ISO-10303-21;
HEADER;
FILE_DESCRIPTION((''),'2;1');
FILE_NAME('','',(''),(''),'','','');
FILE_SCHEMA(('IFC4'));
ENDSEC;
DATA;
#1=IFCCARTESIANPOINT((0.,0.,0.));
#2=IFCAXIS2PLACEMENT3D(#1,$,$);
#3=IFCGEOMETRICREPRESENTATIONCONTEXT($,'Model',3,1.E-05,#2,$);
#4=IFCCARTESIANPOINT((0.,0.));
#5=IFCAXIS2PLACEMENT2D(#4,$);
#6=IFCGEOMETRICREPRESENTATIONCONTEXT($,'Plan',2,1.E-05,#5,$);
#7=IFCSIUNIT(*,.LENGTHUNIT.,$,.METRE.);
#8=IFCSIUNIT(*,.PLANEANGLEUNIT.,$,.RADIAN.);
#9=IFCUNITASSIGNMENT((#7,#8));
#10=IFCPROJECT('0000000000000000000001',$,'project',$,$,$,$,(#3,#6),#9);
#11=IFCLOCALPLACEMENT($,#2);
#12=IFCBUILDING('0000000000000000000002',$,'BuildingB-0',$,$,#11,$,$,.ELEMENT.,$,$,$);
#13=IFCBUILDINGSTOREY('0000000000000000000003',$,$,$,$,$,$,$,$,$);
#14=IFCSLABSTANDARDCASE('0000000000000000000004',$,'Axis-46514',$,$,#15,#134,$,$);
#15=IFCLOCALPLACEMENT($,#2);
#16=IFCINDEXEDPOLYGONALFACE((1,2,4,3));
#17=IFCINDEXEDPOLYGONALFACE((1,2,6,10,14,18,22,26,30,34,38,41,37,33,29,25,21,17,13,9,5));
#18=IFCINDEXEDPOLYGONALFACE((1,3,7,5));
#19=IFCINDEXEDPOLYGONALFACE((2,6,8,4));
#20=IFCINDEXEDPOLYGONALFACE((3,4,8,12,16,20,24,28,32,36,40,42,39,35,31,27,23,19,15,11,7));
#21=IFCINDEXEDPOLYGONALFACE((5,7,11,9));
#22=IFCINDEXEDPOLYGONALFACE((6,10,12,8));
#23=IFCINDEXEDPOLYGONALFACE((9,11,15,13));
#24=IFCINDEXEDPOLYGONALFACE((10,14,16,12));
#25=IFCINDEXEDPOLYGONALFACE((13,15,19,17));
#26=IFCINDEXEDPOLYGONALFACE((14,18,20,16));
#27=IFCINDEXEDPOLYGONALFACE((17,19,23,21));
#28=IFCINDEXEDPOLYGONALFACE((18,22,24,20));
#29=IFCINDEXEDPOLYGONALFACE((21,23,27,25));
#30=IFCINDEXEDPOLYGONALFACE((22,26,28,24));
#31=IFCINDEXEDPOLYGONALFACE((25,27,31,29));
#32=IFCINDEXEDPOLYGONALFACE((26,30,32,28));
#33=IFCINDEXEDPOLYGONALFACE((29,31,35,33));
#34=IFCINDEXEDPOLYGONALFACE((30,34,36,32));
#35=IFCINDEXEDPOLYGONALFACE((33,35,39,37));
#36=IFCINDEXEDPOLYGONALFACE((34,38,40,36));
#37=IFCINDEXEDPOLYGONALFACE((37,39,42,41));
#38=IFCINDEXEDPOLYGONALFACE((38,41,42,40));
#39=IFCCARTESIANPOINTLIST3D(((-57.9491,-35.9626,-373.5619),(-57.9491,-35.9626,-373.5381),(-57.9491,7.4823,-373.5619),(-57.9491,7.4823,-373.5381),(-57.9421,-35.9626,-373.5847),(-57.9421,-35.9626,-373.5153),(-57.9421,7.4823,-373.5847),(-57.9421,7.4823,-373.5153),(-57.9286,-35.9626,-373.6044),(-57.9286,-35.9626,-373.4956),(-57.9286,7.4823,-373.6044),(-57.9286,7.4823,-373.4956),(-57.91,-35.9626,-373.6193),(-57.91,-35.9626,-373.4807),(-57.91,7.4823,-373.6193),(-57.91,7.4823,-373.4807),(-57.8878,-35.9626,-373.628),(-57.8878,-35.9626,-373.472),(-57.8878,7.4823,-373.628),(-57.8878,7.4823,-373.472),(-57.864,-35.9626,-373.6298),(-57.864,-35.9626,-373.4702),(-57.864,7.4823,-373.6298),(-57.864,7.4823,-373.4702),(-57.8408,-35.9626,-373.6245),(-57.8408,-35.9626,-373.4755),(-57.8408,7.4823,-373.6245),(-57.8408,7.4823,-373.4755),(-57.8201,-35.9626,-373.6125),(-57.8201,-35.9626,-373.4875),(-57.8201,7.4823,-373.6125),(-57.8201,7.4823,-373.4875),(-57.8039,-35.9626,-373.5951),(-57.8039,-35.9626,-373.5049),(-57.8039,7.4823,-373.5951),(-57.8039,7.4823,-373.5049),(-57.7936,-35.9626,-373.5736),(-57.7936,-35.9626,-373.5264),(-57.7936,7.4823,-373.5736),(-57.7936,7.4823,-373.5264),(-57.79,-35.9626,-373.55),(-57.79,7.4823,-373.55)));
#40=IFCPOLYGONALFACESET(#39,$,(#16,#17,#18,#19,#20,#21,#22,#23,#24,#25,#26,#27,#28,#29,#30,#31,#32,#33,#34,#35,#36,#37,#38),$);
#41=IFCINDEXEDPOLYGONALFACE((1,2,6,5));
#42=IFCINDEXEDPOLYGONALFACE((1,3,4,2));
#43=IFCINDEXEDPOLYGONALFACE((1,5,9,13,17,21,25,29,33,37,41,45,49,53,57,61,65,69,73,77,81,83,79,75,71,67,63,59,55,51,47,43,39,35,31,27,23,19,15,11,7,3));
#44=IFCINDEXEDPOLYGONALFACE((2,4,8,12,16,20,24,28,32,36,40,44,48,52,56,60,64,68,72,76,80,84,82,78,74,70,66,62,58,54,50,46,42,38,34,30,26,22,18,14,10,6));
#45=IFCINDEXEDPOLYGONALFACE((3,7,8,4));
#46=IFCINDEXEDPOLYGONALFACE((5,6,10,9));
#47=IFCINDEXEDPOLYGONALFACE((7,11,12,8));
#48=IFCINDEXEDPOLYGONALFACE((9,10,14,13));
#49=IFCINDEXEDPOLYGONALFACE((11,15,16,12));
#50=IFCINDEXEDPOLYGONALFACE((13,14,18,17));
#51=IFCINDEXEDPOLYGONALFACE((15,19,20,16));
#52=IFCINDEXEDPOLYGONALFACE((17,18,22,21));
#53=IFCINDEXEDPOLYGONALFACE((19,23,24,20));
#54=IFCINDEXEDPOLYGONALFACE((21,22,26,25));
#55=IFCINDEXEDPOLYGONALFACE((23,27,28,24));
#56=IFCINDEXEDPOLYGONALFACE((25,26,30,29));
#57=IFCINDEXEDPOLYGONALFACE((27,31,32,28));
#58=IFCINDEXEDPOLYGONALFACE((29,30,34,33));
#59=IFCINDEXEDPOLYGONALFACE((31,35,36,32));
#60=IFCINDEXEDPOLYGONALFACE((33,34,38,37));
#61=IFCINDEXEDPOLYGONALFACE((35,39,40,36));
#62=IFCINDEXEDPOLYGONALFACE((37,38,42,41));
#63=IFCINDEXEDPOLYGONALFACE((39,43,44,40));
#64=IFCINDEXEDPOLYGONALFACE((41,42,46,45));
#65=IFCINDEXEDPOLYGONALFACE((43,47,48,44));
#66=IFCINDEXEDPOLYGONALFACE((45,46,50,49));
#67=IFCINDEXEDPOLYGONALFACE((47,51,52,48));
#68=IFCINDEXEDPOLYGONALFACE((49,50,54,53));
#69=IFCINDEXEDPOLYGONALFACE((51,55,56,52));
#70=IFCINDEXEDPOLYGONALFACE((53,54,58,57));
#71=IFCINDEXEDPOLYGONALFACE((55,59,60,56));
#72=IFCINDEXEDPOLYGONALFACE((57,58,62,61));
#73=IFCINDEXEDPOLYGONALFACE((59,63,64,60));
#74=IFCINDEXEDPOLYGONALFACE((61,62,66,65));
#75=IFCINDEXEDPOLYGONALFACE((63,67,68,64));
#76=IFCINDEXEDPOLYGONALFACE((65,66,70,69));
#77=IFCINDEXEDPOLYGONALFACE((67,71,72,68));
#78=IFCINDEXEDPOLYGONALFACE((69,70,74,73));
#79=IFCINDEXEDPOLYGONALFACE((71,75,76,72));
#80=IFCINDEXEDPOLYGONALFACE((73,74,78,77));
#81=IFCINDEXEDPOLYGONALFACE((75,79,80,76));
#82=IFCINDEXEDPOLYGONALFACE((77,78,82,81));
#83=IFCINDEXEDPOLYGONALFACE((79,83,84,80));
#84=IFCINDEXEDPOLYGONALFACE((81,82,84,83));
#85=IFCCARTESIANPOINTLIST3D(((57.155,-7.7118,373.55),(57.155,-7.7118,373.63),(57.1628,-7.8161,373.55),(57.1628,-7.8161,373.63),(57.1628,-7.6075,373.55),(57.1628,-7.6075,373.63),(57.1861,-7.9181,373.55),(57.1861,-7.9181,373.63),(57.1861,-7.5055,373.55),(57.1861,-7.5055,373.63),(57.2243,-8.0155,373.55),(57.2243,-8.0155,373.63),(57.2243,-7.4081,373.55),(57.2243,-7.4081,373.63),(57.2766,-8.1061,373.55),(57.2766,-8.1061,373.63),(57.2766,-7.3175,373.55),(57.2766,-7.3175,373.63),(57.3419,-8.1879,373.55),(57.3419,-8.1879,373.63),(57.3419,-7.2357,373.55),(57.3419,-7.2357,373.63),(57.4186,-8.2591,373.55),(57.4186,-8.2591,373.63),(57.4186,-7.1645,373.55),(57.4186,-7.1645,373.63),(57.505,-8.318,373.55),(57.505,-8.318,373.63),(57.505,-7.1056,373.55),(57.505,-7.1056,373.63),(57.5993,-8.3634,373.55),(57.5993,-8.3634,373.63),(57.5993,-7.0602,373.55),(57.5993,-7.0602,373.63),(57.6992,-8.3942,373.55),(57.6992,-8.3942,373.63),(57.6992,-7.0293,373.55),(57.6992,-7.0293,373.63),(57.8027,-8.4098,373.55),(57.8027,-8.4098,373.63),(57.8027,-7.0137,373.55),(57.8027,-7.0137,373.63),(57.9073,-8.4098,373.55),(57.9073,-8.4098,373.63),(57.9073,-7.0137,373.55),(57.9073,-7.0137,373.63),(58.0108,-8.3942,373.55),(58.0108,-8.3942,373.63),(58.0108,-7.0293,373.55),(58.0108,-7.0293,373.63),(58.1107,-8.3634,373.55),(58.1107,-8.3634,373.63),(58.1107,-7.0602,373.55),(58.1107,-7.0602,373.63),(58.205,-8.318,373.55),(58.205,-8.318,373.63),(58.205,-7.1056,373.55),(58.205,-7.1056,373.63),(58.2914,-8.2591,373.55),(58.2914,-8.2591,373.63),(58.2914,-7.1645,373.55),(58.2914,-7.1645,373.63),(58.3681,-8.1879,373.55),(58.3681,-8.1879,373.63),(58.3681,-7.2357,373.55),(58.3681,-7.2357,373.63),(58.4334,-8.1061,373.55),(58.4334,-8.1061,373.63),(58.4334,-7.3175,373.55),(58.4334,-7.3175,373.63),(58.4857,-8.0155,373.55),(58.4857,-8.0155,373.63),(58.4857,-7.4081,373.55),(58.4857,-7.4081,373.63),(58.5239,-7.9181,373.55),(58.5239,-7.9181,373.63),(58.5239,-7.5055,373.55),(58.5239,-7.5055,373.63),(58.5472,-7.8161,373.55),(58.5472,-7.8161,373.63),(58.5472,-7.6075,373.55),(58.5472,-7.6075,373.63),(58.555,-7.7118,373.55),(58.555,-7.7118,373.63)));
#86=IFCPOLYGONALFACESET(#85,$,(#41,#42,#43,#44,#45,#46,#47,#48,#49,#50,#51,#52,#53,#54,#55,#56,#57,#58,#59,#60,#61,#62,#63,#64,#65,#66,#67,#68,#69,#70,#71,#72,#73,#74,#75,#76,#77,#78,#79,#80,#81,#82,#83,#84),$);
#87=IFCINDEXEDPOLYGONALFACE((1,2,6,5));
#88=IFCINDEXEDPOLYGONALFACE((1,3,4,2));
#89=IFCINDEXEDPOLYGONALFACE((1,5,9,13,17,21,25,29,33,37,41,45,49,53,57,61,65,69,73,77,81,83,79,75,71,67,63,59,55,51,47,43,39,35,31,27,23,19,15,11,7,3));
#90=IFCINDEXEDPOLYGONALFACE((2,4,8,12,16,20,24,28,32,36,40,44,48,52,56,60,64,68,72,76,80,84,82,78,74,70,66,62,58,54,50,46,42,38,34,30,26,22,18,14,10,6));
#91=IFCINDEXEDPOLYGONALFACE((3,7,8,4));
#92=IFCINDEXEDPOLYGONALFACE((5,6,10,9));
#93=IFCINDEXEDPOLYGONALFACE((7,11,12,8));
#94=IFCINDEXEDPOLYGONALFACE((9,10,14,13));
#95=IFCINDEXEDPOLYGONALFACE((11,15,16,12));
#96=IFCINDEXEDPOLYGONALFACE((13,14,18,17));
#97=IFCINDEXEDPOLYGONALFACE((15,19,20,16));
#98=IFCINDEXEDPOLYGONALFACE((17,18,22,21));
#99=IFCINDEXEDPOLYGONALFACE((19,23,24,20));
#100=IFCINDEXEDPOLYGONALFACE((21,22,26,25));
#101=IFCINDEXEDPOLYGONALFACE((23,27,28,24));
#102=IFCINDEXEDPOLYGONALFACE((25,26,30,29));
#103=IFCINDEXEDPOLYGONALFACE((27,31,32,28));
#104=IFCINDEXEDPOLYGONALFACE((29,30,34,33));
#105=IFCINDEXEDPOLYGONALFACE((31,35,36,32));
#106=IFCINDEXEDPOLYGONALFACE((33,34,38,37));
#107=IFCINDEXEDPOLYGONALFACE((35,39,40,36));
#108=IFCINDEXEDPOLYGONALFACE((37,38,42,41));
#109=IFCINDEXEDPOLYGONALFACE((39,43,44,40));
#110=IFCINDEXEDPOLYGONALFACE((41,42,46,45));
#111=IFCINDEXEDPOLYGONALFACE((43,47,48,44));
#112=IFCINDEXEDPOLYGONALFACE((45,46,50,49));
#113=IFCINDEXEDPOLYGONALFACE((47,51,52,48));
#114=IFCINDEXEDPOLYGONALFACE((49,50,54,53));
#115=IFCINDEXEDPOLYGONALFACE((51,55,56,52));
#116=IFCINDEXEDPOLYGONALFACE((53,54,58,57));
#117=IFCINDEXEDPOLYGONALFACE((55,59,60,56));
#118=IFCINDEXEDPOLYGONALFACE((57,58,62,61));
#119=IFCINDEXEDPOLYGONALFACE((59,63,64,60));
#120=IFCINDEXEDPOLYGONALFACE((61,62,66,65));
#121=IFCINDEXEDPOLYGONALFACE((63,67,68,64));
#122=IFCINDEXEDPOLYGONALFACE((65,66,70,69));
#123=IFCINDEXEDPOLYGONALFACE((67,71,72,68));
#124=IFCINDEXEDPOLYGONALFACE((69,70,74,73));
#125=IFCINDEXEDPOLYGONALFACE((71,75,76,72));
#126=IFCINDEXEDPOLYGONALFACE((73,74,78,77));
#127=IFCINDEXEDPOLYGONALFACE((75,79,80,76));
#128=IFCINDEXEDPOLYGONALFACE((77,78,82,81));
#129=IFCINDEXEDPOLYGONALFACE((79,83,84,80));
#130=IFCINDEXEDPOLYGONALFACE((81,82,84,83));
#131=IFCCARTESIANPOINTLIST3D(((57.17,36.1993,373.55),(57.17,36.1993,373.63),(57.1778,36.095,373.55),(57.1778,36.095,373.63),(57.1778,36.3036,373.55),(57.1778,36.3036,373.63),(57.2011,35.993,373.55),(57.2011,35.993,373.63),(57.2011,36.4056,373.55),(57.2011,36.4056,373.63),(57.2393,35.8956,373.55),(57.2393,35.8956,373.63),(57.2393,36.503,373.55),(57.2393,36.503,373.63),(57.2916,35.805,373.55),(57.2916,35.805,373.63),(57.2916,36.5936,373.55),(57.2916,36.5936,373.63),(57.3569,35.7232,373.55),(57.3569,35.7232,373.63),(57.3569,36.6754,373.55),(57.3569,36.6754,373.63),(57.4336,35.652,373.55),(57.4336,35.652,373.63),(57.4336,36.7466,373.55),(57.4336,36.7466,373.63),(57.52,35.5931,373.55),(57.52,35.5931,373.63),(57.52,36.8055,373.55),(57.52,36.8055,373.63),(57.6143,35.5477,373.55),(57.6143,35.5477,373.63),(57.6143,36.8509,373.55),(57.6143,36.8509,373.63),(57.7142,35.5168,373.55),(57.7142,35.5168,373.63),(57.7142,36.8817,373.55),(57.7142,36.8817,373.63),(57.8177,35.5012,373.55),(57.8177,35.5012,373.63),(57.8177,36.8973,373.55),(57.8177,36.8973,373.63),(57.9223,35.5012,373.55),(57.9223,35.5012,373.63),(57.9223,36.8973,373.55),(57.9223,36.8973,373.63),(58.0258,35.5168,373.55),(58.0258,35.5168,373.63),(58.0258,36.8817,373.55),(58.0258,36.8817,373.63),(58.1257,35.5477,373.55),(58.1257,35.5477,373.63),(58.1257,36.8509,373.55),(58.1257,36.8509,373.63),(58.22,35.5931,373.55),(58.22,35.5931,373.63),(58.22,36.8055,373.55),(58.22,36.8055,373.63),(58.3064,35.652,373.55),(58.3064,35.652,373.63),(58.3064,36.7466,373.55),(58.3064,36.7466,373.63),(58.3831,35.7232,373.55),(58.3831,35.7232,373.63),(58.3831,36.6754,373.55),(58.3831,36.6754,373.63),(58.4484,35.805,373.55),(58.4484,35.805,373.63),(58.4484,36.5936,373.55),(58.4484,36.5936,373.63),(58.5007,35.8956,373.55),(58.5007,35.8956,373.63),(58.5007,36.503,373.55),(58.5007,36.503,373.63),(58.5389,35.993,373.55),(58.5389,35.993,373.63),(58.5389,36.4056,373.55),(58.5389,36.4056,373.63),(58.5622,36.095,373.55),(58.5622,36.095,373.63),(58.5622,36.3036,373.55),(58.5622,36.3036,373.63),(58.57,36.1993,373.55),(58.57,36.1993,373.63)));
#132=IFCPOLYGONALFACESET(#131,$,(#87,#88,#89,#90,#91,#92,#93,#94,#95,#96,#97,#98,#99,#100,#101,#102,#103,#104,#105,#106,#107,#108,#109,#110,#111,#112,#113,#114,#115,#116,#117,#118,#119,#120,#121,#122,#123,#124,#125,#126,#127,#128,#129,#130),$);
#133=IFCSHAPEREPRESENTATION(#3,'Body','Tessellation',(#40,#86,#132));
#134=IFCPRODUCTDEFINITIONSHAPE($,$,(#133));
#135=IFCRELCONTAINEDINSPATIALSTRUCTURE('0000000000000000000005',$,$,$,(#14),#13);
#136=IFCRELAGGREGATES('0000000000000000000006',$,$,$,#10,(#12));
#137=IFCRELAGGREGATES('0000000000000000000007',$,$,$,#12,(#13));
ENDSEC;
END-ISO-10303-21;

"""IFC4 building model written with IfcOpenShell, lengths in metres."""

from ifc_helpers import new_model, entity, si_unit, frame, origin, origin_2d, place, context, project, spatial, circle, extrude, element, save


model = new_model("IFC4")

# Units and contexts
model_context = context("Model", 3, precision=1e-05, world=origin())
plan_context = context("Plan", 2, precision=1e-05, world=origin_2d())
ifc_project = project(units=[si_unit("LENGTHUNIT", "METRE"), si_unit("PLANEANGLEUNIT", "RADIAN")], contexts=[model_context, plan_context])

# Building, storey
building_placement = place(None, origin())
building = spatial("IfcBuilding", under=ifc_project, at=building_placement, Name="BuildingB-0", CompositionType="ELEMENT")
storey = spatial("IfcBuildingStorey", under=building)

# Slab
element("IfcSlabStandardCase", 1, inside=storey, Name="Axis-46514", context=model_context, shape_type="AdvancedSweptSolid", body=[
    entity("IfcSurfaceCurveSweptAreaSolid", entity("IfcCircleProfileDef", "AREA", None, None, 0.08), None, entity("IfcPolyline", [entity("IfcCartesianPoint", [57.87, -7.4823, 373.55]), entity("IfcCartesianPoint", [57.87, 35.9626, 373.55])]), None, None, entity("IfcPlane", entity("IfcAxis2Placement3D", entity("IfcCartesianPoint", [57.87, -7.4823, 373.55]), entity("IfcDirection", [0.0, 0.0, 1.0]), entity("IfcDirection", [1.0, 0.0, 0.0])))),
    extrude(circle(Radius=0.7), frame((57.855, -7.7118, 373.55)), (0.0, 0.0, 1.0), 0.08),
    extrude(circle(Radius=0.7), frame((57.87, 36.1993, 373.55)), (0.0, 0.0, 1.0), 0.08),
])

save(model, "model.ifc")
